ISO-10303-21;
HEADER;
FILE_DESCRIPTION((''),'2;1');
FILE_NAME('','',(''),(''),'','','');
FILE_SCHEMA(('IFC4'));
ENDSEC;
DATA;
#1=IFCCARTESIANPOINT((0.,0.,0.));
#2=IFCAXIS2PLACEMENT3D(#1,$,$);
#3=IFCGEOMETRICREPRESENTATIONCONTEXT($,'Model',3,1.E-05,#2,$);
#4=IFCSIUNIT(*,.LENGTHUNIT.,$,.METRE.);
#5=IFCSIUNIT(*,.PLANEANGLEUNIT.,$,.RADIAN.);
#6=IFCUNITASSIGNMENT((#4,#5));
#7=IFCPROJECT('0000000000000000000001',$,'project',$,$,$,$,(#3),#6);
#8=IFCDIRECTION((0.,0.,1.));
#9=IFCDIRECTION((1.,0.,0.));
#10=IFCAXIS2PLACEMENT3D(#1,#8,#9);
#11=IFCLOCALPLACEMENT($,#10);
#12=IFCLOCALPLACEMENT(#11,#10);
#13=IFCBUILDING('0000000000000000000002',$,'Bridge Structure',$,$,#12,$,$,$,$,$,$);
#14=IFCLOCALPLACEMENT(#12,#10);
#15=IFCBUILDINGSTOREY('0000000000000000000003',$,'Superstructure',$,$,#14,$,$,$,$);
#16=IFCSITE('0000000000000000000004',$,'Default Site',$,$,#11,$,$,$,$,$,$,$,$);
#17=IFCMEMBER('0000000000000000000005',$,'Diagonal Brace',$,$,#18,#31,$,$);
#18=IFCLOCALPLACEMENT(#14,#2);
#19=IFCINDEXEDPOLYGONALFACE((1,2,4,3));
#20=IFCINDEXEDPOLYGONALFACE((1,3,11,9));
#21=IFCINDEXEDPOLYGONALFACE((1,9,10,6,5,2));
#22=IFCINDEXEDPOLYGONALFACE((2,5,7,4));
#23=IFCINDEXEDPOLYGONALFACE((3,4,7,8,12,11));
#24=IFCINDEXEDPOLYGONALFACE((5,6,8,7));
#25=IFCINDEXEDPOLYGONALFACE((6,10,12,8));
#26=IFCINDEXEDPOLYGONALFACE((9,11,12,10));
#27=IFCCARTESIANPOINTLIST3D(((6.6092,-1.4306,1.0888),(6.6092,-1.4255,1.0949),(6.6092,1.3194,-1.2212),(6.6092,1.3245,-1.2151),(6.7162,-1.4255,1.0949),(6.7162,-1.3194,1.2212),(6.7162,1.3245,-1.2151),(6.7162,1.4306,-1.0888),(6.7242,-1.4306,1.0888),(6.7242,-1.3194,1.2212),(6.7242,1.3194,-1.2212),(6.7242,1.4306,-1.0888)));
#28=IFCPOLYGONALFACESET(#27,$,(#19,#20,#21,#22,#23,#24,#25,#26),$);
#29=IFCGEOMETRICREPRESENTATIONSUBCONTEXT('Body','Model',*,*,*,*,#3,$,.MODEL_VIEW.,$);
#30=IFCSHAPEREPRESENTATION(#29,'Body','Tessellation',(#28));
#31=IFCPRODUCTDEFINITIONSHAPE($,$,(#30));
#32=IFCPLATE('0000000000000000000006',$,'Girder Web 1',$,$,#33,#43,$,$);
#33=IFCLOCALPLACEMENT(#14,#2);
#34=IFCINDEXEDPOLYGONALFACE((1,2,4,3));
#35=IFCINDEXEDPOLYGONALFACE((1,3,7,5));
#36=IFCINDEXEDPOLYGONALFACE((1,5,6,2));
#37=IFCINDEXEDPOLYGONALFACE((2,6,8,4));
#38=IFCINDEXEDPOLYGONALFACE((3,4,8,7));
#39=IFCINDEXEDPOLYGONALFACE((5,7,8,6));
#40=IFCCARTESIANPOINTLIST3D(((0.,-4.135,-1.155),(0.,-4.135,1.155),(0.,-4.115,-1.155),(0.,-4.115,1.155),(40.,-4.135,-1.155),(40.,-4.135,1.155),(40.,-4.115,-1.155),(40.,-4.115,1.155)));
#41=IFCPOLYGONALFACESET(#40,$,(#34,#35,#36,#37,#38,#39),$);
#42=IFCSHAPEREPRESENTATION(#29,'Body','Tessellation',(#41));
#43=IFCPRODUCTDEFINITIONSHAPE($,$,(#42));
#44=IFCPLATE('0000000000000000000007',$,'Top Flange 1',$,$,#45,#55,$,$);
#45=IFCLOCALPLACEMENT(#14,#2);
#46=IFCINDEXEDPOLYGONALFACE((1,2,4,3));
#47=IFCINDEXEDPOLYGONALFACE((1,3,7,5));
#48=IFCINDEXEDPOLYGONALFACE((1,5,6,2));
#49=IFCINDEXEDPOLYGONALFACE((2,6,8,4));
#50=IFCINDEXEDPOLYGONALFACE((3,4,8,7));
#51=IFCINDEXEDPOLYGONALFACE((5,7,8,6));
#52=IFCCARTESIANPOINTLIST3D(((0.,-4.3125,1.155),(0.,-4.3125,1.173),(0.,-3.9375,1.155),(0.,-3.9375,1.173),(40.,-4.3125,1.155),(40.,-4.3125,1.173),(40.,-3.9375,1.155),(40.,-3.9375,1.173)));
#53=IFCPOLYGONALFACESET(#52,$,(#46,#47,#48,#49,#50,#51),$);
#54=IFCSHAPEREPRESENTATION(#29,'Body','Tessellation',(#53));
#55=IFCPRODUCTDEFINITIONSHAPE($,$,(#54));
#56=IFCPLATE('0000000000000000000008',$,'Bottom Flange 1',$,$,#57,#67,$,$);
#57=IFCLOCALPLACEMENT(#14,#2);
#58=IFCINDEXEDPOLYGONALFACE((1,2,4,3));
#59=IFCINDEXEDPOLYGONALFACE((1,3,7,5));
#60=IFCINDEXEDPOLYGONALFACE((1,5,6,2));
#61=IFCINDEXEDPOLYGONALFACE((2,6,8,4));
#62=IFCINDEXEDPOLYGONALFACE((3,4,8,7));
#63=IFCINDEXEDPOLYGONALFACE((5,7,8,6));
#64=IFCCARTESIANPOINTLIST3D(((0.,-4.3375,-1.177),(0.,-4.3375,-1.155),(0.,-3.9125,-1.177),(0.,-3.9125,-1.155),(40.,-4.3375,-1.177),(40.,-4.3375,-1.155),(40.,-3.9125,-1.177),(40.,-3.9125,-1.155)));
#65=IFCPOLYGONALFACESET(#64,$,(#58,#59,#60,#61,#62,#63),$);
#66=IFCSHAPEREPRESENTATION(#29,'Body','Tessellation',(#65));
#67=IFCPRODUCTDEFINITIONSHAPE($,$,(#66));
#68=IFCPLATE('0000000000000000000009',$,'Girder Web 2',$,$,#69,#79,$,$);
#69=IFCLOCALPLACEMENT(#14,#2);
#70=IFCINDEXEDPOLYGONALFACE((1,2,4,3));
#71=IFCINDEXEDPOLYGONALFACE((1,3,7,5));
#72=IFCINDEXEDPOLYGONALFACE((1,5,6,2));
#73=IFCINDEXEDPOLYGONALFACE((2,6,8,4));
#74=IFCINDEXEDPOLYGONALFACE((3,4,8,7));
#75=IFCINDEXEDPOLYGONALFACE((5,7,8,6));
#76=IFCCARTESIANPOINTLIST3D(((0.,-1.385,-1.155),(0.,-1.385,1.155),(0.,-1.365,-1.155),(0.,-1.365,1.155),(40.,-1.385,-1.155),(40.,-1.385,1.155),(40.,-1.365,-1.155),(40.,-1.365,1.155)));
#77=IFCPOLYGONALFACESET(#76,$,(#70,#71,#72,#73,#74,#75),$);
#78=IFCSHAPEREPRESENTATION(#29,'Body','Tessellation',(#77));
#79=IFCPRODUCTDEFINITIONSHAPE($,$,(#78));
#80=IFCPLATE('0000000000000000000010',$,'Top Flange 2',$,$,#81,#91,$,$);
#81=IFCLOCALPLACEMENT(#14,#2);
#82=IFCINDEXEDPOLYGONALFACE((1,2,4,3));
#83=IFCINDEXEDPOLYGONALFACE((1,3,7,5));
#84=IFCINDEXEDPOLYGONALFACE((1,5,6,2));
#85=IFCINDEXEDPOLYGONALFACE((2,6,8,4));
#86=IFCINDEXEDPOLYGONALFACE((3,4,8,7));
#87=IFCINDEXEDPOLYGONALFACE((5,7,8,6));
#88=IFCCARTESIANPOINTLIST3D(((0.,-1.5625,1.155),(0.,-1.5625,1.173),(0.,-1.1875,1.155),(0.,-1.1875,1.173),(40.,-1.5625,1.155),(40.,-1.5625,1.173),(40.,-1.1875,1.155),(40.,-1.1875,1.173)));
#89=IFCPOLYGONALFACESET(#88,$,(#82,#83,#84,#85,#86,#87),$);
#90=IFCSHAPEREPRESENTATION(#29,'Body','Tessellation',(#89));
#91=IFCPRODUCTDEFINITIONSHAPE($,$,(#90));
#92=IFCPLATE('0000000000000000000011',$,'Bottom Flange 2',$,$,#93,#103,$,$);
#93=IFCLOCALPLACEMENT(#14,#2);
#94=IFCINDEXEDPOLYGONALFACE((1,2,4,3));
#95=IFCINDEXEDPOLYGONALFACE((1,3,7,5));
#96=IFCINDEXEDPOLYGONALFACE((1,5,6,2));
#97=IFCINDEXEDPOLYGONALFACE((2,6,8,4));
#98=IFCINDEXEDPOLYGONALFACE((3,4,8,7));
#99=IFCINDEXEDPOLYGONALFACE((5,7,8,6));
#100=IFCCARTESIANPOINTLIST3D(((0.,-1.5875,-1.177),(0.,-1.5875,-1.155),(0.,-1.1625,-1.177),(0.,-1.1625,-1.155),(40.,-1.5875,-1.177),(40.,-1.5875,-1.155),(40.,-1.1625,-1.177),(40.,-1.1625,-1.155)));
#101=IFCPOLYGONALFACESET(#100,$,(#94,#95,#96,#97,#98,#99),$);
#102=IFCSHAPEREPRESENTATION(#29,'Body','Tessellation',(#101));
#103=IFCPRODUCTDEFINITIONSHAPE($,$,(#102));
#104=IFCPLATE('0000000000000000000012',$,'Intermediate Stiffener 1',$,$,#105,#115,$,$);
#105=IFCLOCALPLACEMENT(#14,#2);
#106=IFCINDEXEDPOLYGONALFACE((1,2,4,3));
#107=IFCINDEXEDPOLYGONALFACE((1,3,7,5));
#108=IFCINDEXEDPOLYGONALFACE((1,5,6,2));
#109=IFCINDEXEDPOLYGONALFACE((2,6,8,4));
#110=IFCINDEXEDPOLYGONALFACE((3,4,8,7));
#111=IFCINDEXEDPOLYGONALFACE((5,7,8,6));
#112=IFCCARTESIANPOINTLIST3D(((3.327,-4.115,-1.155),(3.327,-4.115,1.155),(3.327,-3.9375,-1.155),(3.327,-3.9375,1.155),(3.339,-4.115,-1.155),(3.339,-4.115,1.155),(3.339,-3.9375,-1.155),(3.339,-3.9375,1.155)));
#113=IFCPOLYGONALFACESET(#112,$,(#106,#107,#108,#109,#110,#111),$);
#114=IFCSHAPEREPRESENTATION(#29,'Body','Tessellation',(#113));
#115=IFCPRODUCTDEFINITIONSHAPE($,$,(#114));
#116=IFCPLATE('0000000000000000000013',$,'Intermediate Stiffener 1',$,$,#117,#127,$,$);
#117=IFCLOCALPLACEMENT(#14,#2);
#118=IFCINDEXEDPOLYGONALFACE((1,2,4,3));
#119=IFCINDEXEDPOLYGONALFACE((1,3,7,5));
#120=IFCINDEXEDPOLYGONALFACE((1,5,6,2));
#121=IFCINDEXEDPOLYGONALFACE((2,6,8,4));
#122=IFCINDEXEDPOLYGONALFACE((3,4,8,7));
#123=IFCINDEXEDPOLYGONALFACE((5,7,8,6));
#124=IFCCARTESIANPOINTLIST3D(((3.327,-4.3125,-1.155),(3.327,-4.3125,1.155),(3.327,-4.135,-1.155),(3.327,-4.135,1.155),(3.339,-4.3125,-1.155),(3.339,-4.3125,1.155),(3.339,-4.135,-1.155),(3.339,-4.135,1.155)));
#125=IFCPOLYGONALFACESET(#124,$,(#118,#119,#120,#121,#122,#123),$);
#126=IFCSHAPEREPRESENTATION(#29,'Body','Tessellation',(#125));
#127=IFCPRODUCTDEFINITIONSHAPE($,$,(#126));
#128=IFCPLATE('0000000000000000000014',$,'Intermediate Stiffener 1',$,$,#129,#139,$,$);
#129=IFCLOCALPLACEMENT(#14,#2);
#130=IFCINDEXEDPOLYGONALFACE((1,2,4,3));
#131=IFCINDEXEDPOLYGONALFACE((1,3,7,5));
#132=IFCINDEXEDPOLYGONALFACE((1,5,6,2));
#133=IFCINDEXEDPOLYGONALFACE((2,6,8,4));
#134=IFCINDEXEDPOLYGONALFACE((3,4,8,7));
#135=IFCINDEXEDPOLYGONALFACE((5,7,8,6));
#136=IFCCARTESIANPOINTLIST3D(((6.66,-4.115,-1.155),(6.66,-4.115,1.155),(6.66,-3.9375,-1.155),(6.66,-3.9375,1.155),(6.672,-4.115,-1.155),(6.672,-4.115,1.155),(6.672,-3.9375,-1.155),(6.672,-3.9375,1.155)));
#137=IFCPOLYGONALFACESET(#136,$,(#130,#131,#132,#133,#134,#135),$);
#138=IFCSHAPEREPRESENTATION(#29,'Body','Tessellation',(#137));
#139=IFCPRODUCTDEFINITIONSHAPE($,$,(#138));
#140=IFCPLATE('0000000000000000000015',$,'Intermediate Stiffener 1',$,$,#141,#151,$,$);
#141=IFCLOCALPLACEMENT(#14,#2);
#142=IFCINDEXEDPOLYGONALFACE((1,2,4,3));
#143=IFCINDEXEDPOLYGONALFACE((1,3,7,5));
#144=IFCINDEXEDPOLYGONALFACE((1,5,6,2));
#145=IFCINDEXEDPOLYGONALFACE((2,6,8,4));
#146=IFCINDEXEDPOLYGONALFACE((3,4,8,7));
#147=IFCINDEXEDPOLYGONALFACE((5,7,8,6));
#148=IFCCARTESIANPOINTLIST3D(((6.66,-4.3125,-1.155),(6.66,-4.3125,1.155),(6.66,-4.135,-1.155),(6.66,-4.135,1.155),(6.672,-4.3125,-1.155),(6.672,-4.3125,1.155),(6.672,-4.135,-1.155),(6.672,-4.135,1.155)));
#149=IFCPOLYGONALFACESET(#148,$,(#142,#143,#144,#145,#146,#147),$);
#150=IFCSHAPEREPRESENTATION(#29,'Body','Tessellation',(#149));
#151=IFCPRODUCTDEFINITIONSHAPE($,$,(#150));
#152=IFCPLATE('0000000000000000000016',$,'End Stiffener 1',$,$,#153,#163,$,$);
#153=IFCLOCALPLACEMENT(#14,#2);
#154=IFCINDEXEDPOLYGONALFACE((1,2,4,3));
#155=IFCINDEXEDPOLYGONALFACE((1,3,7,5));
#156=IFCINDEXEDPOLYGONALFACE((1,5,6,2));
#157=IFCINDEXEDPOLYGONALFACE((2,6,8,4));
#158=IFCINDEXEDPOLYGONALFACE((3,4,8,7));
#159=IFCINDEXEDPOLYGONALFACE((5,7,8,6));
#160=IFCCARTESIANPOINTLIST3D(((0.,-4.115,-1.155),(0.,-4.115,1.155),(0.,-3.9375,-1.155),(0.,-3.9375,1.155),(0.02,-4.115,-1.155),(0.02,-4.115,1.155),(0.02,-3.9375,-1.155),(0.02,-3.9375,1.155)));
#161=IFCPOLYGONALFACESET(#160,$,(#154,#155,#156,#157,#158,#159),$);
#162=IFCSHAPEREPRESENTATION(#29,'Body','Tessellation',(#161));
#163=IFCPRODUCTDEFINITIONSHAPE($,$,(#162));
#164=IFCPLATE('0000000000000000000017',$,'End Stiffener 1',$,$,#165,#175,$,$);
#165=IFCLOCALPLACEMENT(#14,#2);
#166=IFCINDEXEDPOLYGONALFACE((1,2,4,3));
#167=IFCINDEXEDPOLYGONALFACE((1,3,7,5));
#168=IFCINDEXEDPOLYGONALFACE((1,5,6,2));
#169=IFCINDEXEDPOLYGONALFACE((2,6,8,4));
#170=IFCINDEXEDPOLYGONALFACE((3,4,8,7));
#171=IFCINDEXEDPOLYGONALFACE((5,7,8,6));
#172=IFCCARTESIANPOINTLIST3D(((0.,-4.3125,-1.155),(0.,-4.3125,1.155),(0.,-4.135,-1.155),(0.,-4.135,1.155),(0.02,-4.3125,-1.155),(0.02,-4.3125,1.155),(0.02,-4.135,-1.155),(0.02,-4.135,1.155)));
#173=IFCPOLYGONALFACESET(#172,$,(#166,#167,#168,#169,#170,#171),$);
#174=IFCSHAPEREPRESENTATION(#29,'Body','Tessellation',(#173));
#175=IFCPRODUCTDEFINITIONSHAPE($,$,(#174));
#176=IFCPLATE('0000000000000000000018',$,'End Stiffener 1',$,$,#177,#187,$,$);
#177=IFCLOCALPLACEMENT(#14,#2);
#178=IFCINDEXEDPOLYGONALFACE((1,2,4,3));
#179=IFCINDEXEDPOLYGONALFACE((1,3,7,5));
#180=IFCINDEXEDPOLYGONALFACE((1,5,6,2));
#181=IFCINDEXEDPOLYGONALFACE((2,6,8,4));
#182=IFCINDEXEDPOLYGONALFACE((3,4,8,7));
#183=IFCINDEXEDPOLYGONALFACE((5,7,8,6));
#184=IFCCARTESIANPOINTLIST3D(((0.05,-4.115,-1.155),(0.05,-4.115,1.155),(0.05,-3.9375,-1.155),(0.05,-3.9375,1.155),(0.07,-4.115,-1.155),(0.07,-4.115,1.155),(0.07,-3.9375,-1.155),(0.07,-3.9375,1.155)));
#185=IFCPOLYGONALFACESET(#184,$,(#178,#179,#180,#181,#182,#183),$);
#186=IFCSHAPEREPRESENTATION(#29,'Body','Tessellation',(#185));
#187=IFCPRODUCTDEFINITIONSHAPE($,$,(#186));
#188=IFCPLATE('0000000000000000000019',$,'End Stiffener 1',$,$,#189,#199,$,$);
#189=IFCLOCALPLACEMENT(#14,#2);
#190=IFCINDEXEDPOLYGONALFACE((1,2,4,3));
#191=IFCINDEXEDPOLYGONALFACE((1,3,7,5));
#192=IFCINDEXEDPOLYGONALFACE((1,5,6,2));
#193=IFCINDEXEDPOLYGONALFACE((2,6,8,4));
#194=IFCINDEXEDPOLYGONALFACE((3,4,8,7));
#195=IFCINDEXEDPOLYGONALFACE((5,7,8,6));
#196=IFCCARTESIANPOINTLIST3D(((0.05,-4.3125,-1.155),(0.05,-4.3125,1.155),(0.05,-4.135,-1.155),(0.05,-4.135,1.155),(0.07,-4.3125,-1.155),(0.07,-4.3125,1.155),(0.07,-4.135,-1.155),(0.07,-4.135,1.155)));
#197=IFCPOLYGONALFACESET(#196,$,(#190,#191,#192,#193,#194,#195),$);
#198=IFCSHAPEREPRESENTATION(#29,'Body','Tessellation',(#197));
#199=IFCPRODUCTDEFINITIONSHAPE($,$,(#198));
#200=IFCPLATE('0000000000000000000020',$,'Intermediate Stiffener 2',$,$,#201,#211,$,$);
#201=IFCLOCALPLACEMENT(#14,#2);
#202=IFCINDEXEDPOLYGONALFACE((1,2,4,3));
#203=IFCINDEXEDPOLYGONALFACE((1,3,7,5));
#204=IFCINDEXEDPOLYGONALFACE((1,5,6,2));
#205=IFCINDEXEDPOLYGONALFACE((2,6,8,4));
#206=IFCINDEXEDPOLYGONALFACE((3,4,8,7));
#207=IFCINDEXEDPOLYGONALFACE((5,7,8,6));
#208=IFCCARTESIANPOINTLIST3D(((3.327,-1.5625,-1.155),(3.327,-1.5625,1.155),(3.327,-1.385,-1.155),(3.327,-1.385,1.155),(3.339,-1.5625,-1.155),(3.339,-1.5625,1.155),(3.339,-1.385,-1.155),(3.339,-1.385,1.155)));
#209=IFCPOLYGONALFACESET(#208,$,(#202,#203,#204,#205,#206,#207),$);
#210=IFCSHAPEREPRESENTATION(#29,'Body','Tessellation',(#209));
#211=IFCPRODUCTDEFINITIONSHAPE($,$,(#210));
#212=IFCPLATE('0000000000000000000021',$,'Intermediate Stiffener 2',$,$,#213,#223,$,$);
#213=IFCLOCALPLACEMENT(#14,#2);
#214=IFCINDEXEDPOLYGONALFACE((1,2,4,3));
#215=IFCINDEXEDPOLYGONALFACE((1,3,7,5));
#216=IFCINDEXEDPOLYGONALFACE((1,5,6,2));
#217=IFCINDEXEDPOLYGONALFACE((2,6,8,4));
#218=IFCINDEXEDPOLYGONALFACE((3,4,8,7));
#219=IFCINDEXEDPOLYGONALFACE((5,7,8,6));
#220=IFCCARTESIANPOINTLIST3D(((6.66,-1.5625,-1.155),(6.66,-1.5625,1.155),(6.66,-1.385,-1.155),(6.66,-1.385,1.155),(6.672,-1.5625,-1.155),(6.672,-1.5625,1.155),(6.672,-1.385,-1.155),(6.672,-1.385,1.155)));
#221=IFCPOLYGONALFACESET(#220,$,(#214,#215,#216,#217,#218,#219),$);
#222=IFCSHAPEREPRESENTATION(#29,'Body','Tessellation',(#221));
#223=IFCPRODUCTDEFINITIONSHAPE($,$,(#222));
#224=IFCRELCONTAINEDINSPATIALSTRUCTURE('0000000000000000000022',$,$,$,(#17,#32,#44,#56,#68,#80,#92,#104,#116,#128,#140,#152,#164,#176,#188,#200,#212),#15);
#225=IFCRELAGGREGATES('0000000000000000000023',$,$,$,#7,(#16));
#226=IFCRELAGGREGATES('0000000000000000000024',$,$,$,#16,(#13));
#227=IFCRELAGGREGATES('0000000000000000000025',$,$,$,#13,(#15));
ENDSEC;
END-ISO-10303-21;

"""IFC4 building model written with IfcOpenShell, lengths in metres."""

from ifc_helpers import new_model, si_unit, frame, origin, origin_with_axes, origin_2d_with_axis, place, context, subcontext, project, spatial, rectangle, l_section, extrude, element, save


model = new_model("IFC4")

# Units and contexts
model_context = context("Model", 3, precision=1e-05, world=origin())
body_context = subcontext(model_context, "Body", "Model", "MODEL_VIEW")
ifc_project = project(units=[si_unit("LENGTHUNIT", "METRE"), si_unit("PLANEANGLEUNIT", "RADIAN")], contexts=[model_context])

# Site, building, storey
site_placement = place(None, origin_with_axes())
site = spatial("IfcSite", under=ifc_project, at=site_placement, Name="Default Site")
building_placement = place(site_placement, origin_with_axes())
building = spatial("IfcBuilding", under=site, at=building_placement, Name="Bridge Structure")
storey_placement = place(building_placement, origin_with_axes())
storey = spatial("IfcBuildingStorey", under=building, at=storey_placement, Name="Superstructure")

# Member
member_placement = place(storey_placement, frame((6.6667, -1.375, 1.155), z_axis=(0.0, 0.765705, -0.643192), x_axis=(-1.0, 0.0, 0.0)))
element("IfcMember", 1, at=member_placement, inside=storey, Name="Diagonal Brace", context=body_context, shape_type="SweptSolid", body=[
    extrude(l_section(Depth=0.173, Width=0.115, Thickness=0.008, at=origin_2d_with_axis()), origin_with_axes(), (0.0, 0.0, 1.0), 3.5915),
])

# Plates
plate_1_placement = place(storey_placement, frame((0.0, -4.125, 0.0), z_axis=(1.0, 0.0, 0.0), x_axis=(0.0, 1.0, 0.0)))
element("IfcPlate", 2, at=plate_1_placement, inside=storey, Name="Girder Web 1", context=body_context, shape_type="SweptSolid", body=[
    extrude(rectangle(XDim=0.02, YDim=2.31, at=origin_2d_with_axis()), origin_with_axes(), (0.0, 0.0, 1.0), 40.0),
])
plate_2_placement = place(storey_placement, frame((0.0, -4.125, 1.164), z_axis=(1.0, 0.0, 0.0), x_axis=(0.0, 1.0, 0.0)))
element("IfcPlate", 3, at=plate_2_placement, inside=storey, Name="Top Flange 1", context=body_context, shape_type="SweptSolid", body=[
    extrude(rectangle(XDim=0.375, YDim=0.018, at=origin_2d_with_axis()), origin_with_axes(), (0.0, 0.0, 1.0), 40.0),
])
plate_3_placement = place(storey_placement, frame((0.0, -4.125, -1.166), z_axis=(1.0, 0.0, 0.0), x_axis=(0.0, 1.0, 0.0)))
element("IfcPlate", 4, at=plate_3_placement, inside=storey, Name="Bottom Flange 1", context=body_context, shape_type="SweptSolid", body=[
    extrude(rectangle(XDim=0.425, YDim=0.022, at=origin_2d_with_axis()), origin_with_axes(), (0.0, 0.0, 1.0), 40.0),
])
plate_4_placement = place(storey_placement, frame((0.0, -1.375, 0.0), z_axis=(1.0, 0.0, 0.0), x_axis=(0.0, 1.0, 0.0)))
element("IfcPlate", 5, at=plate_4_placement, inside=storey, Name="Girder Web 2", context=body_context, shape_type="SweptSolid", body=[
    extrude(rectangle(XDim=0.02, YDim=2.31, at=origin_2d_with_axis()), origin_with_axes(), (0.0, 0.0, 1.0), 40.0),
])
plate_5_placement = place(storey_placement, frame((0.0, -1.375, 1.164), z_axis=(1.0, 0.0, 0.0), x_axis=(0.0, 1.0, 0.0)))
element("IfcPlate", 6, at=plate_5_placement, inside=storey, Name="Top Flange 2", context=body_context, shape_type="SweptSolid", body=[
    extrude(rectangle(XDim=0.375, YDim=0.018, at=origin_2d_with_axis()), origin_with_axes(), (0.0, 0.0, 1.0), 40.0),
])
plate_6_placement = place(storey_placement, frame((0.0, -1.375, -1.166), z_axis=(1.0, 0.0, 0.0), x_axis=(0.0, 1.0, 0.0)))
element("IfcPlate", 7, at=plate_6_placement, inside=storey, Name="Bottom Flange 2", context=body_context, shape_type="SweptSolid", body=[
    extrude(rectangle(XDim=0.425, YDim=0.022, at=origin_2d_with_axis()), origin_with_axes(), (0.0, 0.0, 1.0), 40.0),
])
for number, where, z_axis, x_axis, name in (
    (8, (3.333, -4.0263, -1.155), (0.0, 0.0, 1.0), (1.0, 0.0, 0.0), "Intermediate Stiffener 1"),
    (9, (3.333, -4.2237, -1.155), (0.0, 0.0, 1.0), (1.0, 0.0, 0.0), "Intermediate Stiffener 1"),
    (10, (6.666, -4.0263, -1.155), (0.0, 0.0, 1.0), (1.0, 0.0, 0.0), "Intermediate Stiffener 1"),
    (11, (6.666, -4.2237, -1.155), (0.0, 0.0, 1.0), (1.0, 0.0, 0.0), "Intermediate Stiffener 1"),
):
    element("IfcPlate", number, at=place(storey_placement, frame(where, z_axis=z_axis, x_axis=x_axis)), inside=storey, Name=name, context=body_context, shape_type="SweptSolid", body=[
        extrude(rectangle(XDim=0.012, YDim=0.1775, at=origin_2d_with_axis()), origin_with_axes(), (0.0, 0.0, 1.0), 2.31),
    ])
for number, where, z_axis, x_axis, name in (
    (12, (0.01, -4.0263, -1.155), (0.0, 0.0, 1.0), (1.0, 0.0, 0.0), "End Stiffener 1"),
    (13, (0.01, -4.2237, -1.155), (0.0, 0.0, 1.0), (1.0, 0.0, 0.0), "End Stiffener 1"),
    (14, (0.06, -4.0263, -1.155), (0.0, 0.0, 1.0), (1.0, 0.0, 0.0), "End Stiffener 1"),
    (15, (0.06, -4.2237, -1.155), (0.0, 0.0, 1.0), (1.0, 0.0, 0.0), "End Stiffener 1"),
):
    element("IfcPlate", number, at=place(storey_placement, frame(where, z_axis=z_axis, x_axis=x_axis)), inside=storey, Name=name, context=body_context, shape_type="SweptSolid", body=[
        extrude(rectangle(XDim=0.02, YDim=0.1775, at=origin_2d_with_axis()), origin_with_axes(), (0.0, 0.0, 1.0), 2.31),
    ])
for number, where, z_axis, x_axis, name in (
    (16, (3.333, -1.4738, -1.155), (0.0, 0.0, 1.0), (1.0, 0.0, 0.0), "Intermediate Stiffener 2"),
    (17, (6.666, -1.4738, -1.155), (0.0, 0.0, 1.0), (1.0, 0.0, 0.0), "Intermediate Stiffener 2"),
):
    element("IfcPlate", number, at=place(storey_placement, frame(where, z_axis=z_axis, x_axis=x_axis)), inside=storey, Name=name, context=body_context, shape_type="SweptSolid", body=[
        extrude(rectangle(XDim=0.012, YDim=0.1775, at=origin_2d_with_axis()), origin_with_axes(), (0.0, 0.0, 1.0), 2.31),
    ])

save(model, "model.ifc")
